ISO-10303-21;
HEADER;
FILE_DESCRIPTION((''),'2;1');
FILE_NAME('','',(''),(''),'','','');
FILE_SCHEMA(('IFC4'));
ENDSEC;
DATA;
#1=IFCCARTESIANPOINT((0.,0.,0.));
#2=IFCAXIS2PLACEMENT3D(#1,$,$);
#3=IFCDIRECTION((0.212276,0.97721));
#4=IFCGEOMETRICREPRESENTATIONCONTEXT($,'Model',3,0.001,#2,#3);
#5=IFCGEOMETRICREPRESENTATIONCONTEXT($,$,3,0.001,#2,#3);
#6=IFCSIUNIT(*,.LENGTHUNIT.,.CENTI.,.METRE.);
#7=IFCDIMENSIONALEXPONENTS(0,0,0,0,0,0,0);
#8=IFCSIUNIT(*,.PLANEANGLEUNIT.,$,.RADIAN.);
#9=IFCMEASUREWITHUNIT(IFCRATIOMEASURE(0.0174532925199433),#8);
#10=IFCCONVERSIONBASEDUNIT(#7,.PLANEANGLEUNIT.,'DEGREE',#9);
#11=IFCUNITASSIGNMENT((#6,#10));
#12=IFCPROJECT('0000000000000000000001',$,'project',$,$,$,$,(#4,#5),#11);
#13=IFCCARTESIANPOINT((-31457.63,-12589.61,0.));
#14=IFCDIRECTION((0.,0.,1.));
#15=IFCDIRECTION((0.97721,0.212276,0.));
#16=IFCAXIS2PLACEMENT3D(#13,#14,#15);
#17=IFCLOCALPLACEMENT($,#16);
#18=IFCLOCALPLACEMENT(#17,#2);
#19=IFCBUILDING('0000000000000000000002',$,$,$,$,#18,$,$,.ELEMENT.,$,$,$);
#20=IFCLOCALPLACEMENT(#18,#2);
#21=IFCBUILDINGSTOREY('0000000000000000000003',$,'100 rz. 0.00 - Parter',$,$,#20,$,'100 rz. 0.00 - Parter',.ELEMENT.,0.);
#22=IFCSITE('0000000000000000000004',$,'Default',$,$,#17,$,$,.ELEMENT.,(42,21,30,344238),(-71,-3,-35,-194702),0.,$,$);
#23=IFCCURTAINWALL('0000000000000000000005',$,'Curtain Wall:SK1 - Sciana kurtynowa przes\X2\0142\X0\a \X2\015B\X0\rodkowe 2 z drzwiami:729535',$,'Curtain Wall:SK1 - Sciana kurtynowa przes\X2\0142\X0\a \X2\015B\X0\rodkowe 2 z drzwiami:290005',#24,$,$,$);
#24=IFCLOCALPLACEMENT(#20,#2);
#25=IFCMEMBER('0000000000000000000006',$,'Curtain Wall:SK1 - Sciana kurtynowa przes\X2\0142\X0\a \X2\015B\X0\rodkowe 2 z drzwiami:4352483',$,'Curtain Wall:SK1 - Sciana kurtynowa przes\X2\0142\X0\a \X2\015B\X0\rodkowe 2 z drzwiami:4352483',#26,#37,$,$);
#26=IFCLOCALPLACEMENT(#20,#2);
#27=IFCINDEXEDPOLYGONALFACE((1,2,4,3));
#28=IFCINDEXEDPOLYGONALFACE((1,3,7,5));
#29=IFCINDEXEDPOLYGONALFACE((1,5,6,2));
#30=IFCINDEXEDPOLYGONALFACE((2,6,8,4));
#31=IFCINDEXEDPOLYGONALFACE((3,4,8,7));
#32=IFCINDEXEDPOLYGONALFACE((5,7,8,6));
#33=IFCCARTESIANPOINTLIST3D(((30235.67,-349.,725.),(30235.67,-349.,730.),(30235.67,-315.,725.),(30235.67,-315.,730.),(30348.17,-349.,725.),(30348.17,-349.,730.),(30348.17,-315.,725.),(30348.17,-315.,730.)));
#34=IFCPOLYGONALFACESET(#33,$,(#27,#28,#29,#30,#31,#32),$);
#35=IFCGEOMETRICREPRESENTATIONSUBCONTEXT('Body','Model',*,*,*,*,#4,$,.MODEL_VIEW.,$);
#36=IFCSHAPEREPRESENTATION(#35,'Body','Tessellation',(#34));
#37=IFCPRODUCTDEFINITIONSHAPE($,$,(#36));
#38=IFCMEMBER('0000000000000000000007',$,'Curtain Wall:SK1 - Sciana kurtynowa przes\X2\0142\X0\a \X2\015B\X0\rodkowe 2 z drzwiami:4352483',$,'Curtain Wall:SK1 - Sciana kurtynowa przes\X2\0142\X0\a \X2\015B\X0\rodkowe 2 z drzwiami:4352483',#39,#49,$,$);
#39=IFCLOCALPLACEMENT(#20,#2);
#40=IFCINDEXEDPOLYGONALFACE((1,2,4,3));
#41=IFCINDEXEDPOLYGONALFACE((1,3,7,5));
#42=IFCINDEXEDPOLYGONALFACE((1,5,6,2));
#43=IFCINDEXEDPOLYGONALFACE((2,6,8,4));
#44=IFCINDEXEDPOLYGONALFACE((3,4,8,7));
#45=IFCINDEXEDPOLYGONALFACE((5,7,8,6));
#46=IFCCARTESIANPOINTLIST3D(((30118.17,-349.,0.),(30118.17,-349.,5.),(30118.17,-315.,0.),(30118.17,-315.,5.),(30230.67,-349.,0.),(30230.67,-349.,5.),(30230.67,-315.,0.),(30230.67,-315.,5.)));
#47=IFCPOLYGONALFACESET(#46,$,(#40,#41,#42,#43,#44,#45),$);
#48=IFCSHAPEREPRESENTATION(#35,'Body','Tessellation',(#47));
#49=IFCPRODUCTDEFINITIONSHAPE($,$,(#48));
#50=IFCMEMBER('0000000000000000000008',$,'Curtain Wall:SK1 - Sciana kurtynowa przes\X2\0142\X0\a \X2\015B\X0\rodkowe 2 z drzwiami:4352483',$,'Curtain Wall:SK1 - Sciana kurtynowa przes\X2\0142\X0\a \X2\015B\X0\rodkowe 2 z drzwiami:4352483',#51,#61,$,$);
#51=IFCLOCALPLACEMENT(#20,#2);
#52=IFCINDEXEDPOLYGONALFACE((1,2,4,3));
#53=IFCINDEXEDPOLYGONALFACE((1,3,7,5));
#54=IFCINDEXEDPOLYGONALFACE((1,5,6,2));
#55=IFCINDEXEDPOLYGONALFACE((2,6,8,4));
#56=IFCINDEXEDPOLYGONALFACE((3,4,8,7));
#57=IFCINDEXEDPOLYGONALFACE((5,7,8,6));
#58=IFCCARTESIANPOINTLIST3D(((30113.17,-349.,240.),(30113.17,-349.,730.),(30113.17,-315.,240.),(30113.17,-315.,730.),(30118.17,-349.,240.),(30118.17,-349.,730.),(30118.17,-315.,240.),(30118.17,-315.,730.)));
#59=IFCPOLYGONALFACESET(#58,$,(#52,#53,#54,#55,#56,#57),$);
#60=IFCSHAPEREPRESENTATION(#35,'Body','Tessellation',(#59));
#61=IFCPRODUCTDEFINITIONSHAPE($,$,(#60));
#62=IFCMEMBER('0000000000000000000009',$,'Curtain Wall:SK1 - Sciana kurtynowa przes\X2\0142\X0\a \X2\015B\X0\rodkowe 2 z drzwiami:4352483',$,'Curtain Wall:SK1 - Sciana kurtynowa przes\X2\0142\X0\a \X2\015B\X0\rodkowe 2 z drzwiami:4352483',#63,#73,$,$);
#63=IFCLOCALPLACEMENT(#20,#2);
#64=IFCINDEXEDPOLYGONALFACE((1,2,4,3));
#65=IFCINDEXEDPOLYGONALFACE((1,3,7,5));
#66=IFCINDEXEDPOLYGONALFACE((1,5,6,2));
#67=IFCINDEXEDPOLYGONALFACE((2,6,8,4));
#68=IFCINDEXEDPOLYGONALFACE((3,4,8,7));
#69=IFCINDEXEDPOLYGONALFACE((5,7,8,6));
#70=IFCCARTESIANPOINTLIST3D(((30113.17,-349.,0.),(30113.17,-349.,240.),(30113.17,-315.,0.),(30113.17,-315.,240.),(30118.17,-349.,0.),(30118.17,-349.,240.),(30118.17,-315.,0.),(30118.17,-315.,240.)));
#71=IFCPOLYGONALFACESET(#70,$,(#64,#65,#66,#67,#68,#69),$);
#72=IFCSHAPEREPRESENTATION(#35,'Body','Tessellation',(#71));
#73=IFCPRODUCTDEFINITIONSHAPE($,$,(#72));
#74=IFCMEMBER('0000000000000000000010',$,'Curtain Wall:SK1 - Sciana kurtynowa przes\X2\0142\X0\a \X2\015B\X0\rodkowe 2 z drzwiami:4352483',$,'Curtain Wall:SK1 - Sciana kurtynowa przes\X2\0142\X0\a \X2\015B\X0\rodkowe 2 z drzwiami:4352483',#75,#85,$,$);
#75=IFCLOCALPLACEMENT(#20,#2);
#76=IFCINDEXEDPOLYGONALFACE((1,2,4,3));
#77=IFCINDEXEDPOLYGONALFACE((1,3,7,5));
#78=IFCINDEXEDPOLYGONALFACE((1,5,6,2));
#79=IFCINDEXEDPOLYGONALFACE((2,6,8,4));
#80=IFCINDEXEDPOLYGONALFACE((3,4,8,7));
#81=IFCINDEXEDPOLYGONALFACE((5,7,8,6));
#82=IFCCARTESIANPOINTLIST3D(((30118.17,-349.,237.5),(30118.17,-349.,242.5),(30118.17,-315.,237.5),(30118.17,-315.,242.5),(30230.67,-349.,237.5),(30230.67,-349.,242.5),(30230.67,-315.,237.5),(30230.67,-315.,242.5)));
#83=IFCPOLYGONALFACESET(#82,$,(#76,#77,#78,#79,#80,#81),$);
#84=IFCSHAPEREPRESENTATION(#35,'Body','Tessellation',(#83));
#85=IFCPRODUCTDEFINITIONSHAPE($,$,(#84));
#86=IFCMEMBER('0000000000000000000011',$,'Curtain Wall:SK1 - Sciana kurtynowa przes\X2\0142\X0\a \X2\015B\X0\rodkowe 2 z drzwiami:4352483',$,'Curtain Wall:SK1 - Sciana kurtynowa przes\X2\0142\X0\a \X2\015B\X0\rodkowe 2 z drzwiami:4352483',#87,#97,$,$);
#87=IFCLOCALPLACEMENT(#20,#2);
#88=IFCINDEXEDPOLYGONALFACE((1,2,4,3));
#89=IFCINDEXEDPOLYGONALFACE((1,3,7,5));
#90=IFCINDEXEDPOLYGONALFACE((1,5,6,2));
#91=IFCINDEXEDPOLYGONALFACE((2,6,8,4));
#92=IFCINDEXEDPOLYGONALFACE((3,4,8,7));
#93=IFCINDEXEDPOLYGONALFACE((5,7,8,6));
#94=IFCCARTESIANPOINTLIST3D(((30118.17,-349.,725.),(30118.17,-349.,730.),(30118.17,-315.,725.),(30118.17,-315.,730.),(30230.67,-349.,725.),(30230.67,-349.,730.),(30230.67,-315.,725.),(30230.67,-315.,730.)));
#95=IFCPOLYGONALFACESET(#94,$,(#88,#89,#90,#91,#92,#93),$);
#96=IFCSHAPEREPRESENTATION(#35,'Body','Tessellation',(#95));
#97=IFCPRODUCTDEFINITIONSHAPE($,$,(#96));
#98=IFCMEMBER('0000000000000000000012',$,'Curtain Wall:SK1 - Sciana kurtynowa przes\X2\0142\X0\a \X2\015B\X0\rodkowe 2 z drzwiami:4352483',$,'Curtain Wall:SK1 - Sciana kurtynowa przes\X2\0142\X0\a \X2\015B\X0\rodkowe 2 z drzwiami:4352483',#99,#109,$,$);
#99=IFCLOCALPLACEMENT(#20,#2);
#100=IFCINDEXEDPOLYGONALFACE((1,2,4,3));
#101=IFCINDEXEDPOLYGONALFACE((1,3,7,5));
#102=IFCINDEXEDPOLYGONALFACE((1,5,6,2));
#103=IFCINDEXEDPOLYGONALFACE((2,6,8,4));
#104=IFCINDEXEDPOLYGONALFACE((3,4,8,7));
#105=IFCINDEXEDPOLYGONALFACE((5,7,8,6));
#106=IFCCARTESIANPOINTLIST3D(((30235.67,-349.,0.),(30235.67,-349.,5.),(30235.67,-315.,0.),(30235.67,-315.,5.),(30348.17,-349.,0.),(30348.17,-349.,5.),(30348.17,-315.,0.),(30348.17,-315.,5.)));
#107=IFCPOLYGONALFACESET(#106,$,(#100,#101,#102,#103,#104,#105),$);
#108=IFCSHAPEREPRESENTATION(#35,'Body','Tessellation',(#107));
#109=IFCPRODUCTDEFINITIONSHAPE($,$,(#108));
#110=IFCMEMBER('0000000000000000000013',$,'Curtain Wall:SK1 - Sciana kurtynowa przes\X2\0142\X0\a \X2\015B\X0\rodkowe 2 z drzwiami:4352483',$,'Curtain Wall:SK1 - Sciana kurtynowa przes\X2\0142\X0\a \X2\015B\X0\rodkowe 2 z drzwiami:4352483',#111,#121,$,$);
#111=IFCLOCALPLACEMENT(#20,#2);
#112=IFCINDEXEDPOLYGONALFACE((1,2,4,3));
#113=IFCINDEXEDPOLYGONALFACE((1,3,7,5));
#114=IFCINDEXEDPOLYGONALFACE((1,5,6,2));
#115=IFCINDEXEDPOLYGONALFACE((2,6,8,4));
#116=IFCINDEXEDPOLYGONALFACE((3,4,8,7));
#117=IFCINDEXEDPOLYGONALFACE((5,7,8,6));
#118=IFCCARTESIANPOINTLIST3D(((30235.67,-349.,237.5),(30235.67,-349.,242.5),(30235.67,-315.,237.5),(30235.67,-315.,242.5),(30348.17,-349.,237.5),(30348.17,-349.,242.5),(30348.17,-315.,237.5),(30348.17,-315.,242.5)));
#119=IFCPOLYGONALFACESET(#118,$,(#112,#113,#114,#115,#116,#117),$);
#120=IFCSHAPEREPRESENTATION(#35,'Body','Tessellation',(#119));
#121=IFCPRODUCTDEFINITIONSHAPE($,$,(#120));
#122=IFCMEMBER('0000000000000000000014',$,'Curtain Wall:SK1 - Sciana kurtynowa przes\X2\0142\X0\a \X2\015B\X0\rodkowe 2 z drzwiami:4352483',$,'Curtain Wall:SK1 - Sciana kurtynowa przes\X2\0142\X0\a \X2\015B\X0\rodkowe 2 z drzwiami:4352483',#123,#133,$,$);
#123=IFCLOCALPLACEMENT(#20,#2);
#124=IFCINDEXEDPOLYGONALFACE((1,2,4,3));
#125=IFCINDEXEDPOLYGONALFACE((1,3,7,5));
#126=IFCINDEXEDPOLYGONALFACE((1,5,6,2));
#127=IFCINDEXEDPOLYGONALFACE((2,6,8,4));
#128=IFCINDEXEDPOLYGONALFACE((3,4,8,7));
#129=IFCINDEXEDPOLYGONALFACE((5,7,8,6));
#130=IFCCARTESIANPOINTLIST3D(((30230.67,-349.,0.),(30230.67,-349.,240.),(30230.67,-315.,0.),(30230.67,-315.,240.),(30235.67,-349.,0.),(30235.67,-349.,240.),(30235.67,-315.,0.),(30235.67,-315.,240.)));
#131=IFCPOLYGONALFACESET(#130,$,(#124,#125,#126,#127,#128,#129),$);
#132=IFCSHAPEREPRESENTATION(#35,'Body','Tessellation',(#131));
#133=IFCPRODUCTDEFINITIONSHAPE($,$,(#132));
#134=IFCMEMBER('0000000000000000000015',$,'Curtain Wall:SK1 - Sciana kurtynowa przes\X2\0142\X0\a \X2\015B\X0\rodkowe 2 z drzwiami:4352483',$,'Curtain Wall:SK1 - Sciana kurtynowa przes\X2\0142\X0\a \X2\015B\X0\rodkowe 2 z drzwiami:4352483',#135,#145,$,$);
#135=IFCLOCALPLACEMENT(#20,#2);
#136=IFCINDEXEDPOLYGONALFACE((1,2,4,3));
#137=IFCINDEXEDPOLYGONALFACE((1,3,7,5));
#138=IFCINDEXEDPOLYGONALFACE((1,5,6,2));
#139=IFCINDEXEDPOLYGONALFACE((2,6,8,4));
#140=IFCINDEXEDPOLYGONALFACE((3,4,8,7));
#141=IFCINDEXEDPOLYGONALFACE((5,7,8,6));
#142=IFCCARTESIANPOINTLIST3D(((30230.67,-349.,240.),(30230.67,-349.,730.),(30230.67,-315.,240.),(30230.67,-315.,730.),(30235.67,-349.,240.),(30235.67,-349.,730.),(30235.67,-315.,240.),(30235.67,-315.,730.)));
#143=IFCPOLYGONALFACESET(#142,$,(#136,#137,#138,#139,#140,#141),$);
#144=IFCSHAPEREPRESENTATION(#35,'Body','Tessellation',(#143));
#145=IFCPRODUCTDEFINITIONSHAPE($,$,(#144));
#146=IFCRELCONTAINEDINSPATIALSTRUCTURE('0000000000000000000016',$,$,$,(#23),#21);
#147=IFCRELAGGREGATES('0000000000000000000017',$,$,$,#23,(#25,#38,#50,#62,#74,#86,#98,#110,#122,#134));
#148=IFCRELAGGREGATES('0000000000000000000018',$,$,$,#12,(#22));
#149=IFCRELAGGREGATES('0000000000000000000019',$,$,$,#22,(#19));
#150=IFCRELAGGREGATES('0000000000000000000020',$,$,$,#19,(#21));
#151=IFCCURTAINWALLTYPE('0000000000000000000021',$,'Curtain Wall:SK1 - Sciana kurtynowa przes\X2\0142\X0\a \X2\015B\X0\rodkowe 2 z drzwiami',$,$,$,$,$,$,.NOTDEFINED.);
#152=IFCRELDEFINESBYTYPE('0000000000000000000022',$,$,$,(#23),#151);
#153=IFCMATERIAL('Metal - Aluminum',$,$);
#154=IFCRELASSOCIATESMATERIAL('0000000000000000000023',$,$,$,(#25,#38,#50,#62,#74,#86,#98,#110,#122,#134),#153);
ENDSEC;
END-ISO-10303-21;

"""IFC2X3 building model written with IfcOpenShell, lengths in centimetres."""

from ifc_helpers import new_model, entity, si_unit, converted_unit, direction, frame, frame_2d, origin, place, context, subcontext, project, spatial, rectangle, extrude, material, type_object, element, aggregate, save


model = new_model("IFC2X3")

# Units and contexts
model_context = context("Model", 3, precision=0.001, world=origin(), true_north=direction((0.212276, 0.97721)))
context_of_model = context(None, 3, precision=0.001, world=origin(), true_north=direction((0.212276, 0.97721)))
body_context = subcontext(model_context, "Body", "Model", "MODEL_VIEW")
ifc_project = project(units=[si_unit("LENGTHUNIT", "METRE", prefix="CENTI"), converted_unit("PLANEANGLEUNIT", "DEGREE", entity("IfcRatioMeasure", 0.0174532925199433), si_unit("PLANEANGLEUNIT", "RADIAN"), dimensions=[0, 0, 0, 0, 0, 0, 0])], contexts=[model_context, context_of_model])

# Site, building, storey
site_placement = place(None, frame((-31457.63, -12589.61, 0.0), z_axis=(0.0, 0.0, 1.0), x_axis=(0.97721, 0.212276, 0.0)))
site = spatial("IfcSite", under=ifc_project, at=site_placement, Name="Default", CompositionType="ELEMENT", RefLatitude=(42, 21, 30, 344238), RefLongitude=(-71, -3, -35, -194702), RefElevation=0.0)
building_placement = place(site_placement, origin())
building = spatial("IfcBuilding", under=site, at=building_placement, CompositionType="ELEMENT")
storey_placement = place(building_placement, origin())
storey = spatial("IfcBuildingStorey", under=building, at=storey_placement, Name="100 rz. 0.00 - Parter", LongName="100 rz. 0.00 - Parter", CompositionType="ELEMENT", Elevation=0.0)

# Curtain wall, members
curtain_wall_type = type_object("IfcCurtainWallType", Name="Curtain Wall:SK1 - Sciana kurtynowa przesła środkowe 2 z drzwiami", PredefinedType="NOTDEFINED")
curtain_wall_placement = place(storey_placement, origin())
curtain_wall = element("IfcCurtainWall", 1, at=curtain_wall_placement, inside=storey, type_object=curtain_wall_type, Name="Curtain Wall:SK1 - Sciana kurtynowa przesła środkowe 2 z drzwiami:729535", ObjectType="Curtain Wall:SK1 - Sciana kurtynowa przesła środkowe 2 z drzwiami:290005")
ifc_material_1 = material(Name="Metal - Aluminum")
member_1_placement = place(curtain_wall_placement, frame((30235.67, -349.0, 725.0)))
member_1 = element("IfcMember", 2, at=member_1_placement, material=ifc_material_1, Name="Curtain Wall:SK1 - Sciana kurtynowa przesła środkowe 2 z drzwiami:4352483", ObjectType="Curtain Wall:SK1 - Sciana kurtynowa przesła środkowe 2 z drzwiami:4352483", context=body_context, shape_type="SweptSolid", body=[
    extrude(rectangle(XDim=112.5, YDim=34.0, at=frame_2d((0.0, 0.0), x_axis=(1.0, 0.0))), frame((56.25, 17.0, 0.0), z_axis=(0.0, 0.0, 1.0), x_axis=(-1.0, 0.0, 0.0)), (0.0, 0.0, 1.0), 5.0),
])
member_2_placement = place(curtain_wall_placement, frame((30118.17, -349.0, 0.0)))
member_2 = element("IfcMember", 3, at=member_2_placement, material=ifc_material_1, Name="Curtain Wall:SK1 - Sciana kurtynowa przesła środkowe 2 z drzwiami:4352483", ObjectType="Curtain Wall:SK1 - Sciana kurtynowa przesła środkowe 2 z drzwiami:4352483", context=body_context, shape_type="SweptSolid", body=[
    extrude(rectangle(XDim=112.5, YDim=34.0, at=frame_2d((0.0, 0.0), x_axis=(1.0, 0.0))), frame((56.25, 17.0, 0.0)), (0.0, 0.0, 1.0), 5.0),
])
member_3_placement = place(curtain_wall_placement, frame((30113.17, -349.0, 240.0)))
member_3 = element("IfcMember", 4, at=member_3_placement, material=ifc_material_1, Name="Curtain Wall:SK1 - Sciana kurtynowa przesła środkowe 2 z drzwiami:4352483", ObjectType="Curtain Wall:SK1 - Sciana kurtynowa przesła środkowe 2 z drzwiami:4352483", context=body_context, shape_type="SweptSolid", body=[
    extrude(rectangle(XDim=5.0, YDim=34.0, at=frame_2d((0.0, 0.0), x_axis=(1.0, 0.0))), frame((2.5, 17.0, 0.0)), (0.0, 0.0, 1.0), 490.0),
])
member_4_placement = place(curtain_wall_placement, frame((30113.17, -349.0, 0.0)))
member_4 = element("IfcMember", 5, at=member_4_placement, material=ifc_material_1, Name="Curtain Wall:SK1 - Sciana kurtynowa przesła środkowe 2 z drzwiami:4352483", ObjectType="Curtain Wall:SK1 - Sciana kurtynowa przesła środkowe 2 z drzwiami:4352483", context=body_context, shape_type="SweptSolid", body=[
    extrude(rectangle(XDim=5.0, YDim=34.0, at=frame_2d((0.0, 0.0), x_axis=(1.0, 0.0))), frame((2.5, 17.0, 0.0)), (0.0, 0.0, 1.0), 240.0),
])
member_5_placement = place(curtain_wall_placement, frame((30118.17, -349.0, 237.5)))
member_5 = element("IfcMember", 6, at=member_5_placement, material=ifc_material_1, Name="Curtain Wall:SK1 - Sciana kurtynowa przesła środkowe 2 z drzwiami:4352483", ObjectType="Curtain Wall:SK1 - Sciana kurtynowa przesła środkowe 2 z drzwiami:4352483", context=body_context, shape_type="SweptSolid", body=[
    extrude(rectangle(XDim=112.5, YDim=34.0, at=frame_2d((0.0, 0.0), x_axis=(1.0, 0.0))), frame((56.25, 17.0, 0.0), z_axis=(0.0, 0.0, 1.0), x_axis=(-1.0, 0.0, 0.0)), (0.0, 0.0, 1.0), 5.0),
])
member_6_placement = place(curtain_wall_placement, frame((30118.17, -349.0, 725.0)))
member_6 = element("IfcMember", 7, at=member_6_placement, material=ifc_material_1, Name="Curtain Wall:SK1 - Sciana kurtynowa przesła środkowe 2 z drzwiami:4352483", ObjectType="Curtain Wall:SK1 - Sciana kurtynowa przesła środkowe 2 z drzwiami:4352483", context=body_context, shape_type="SweptSolid", body=[
    extrude(rectangle(XDim=112.5, YDim=34.0, at=frame_2d((0.0, 0.0), x_axis=(1.0, 0.0))), frame((56.25, 17.0, 0.0), z_axis=(0.0, 0.0, 1.0), x_axis=(-1.0, 0.0, 0.0)), (0.0, 0.0, 1.0), 5.0),
])
member_7_placement = place(curtain_wall_placement, frame((30235.67, -349.0, 0.0)))
member_7 = element("IfcMember", 8, at=member_7_placement, material=ifc_material_1, Name="Curtain Wall:SK1 - Sciana kurtynowa przesła środkowe 2 z drzwiami:4352483", ObjectType="Curtain Wall:SK1 - Sciana kurtynowa przesła środkowe 2 z drzwiami:4352483", context=body_context, shape_type="SweptSolid", body=[
    extrude(rectangle(XDim=112.5, YDim=34.0, at=frame_2d((0.0, 0.0), x_axis=(1.0, 0.0))), frame((56.25, 17.0, 0.0)), (0.0, 0.0, 1.0), 5.0),
])
member_8_placement = place(curtain_wall_placement, frame((30235.67, -349.0, 237.5)))
member_8 = element("IfcMember", 9, at=member_8_placement, material=ifc_material_1, Name="Curtain Wall:SK1 - Sciana kurtynowa przesła środkowe 2 z drzwiami:4352483", ObjectType="Curtain Wall:SK1 - Sciana kurtynowa przesła środkowe 2 z drzwiami:4352483", context=body_context, shape_type="SweptSolid", body=[
    extrude(rectangle(XDim=112.5, YDim=34.0, at=frame_2d((0.0, 0.0), x_axis=(1.0, 0.0))), frame((56.25, 17.0, 0.0), z_axis=(0.0, 0.0, 1.0), x_axis=(-1.0, 0.0, 0.0)), (0.0, 0.0, 1.0), 5.0),
])
member_9_placement = place(curtain_wall_placement, frame((30230.67, -349.0, 0.0)))
member_9 = element("IfcMember", 10, at=member_9_placement, material=ifc_material_1, Name="Curtain Wall:SK1 - Sciana kurtynowa przesła środkowe 2 z drzwiami:4352483", ObjectType="Curtain Wall:SK1 - Sciana kurtynowa przesła środkowe 2 z drzwiami:4352483", context=body_context, shape_type="SweptSolid", body=[
    extrude(rectangle(XDim=34.0, YDim=5.0, at=frame_2d((0.0, 0.0), x_axis=(1.0, 0.0))), frame((2.5, 17.0, 0.0), z_axis=(0.0, 0.0, 1.0), x_axis=(0.0, 1.0, 0.0)), (0.0, 0.0, 1.0), 240.0),
])
member_10_placement = place(curtain_wall_placement, frame((30230.67, -349.0, 240.0)))
member_10 = element("IfcMember", 11, at=member_10_placement, material=ifc_material_1, Name="Curtain Wall:SK1 - Sciana kurtynowa przesła środkowe 2 z drzwiami:4352483", ObjectType="Curtain Wall:SK1 - Sciana kurtynowa przesła środkowe 2 z drzwiami:4352483", context=body_context, shape_type="SweptSolid", body=[
    extrude(rectangle(XDim=34.0, YDim=5.0, at=frame_2d((0.0, 0.0), x_axis=(1.0, 0.0))), frame((2.5, 17.0, 0.0), z_axis=(0.0, 0.0, 1.0), x_axis=(0.0, 1.0, 0.0)), (0.0, 0.0, 1.0), 490.0),
])

aggregate(curtain_wall, [member_1, member_2, member_3, member_4, member_5, member_6, member_7, member_8, member_9, member_10])

save(model, "model.ifc")
